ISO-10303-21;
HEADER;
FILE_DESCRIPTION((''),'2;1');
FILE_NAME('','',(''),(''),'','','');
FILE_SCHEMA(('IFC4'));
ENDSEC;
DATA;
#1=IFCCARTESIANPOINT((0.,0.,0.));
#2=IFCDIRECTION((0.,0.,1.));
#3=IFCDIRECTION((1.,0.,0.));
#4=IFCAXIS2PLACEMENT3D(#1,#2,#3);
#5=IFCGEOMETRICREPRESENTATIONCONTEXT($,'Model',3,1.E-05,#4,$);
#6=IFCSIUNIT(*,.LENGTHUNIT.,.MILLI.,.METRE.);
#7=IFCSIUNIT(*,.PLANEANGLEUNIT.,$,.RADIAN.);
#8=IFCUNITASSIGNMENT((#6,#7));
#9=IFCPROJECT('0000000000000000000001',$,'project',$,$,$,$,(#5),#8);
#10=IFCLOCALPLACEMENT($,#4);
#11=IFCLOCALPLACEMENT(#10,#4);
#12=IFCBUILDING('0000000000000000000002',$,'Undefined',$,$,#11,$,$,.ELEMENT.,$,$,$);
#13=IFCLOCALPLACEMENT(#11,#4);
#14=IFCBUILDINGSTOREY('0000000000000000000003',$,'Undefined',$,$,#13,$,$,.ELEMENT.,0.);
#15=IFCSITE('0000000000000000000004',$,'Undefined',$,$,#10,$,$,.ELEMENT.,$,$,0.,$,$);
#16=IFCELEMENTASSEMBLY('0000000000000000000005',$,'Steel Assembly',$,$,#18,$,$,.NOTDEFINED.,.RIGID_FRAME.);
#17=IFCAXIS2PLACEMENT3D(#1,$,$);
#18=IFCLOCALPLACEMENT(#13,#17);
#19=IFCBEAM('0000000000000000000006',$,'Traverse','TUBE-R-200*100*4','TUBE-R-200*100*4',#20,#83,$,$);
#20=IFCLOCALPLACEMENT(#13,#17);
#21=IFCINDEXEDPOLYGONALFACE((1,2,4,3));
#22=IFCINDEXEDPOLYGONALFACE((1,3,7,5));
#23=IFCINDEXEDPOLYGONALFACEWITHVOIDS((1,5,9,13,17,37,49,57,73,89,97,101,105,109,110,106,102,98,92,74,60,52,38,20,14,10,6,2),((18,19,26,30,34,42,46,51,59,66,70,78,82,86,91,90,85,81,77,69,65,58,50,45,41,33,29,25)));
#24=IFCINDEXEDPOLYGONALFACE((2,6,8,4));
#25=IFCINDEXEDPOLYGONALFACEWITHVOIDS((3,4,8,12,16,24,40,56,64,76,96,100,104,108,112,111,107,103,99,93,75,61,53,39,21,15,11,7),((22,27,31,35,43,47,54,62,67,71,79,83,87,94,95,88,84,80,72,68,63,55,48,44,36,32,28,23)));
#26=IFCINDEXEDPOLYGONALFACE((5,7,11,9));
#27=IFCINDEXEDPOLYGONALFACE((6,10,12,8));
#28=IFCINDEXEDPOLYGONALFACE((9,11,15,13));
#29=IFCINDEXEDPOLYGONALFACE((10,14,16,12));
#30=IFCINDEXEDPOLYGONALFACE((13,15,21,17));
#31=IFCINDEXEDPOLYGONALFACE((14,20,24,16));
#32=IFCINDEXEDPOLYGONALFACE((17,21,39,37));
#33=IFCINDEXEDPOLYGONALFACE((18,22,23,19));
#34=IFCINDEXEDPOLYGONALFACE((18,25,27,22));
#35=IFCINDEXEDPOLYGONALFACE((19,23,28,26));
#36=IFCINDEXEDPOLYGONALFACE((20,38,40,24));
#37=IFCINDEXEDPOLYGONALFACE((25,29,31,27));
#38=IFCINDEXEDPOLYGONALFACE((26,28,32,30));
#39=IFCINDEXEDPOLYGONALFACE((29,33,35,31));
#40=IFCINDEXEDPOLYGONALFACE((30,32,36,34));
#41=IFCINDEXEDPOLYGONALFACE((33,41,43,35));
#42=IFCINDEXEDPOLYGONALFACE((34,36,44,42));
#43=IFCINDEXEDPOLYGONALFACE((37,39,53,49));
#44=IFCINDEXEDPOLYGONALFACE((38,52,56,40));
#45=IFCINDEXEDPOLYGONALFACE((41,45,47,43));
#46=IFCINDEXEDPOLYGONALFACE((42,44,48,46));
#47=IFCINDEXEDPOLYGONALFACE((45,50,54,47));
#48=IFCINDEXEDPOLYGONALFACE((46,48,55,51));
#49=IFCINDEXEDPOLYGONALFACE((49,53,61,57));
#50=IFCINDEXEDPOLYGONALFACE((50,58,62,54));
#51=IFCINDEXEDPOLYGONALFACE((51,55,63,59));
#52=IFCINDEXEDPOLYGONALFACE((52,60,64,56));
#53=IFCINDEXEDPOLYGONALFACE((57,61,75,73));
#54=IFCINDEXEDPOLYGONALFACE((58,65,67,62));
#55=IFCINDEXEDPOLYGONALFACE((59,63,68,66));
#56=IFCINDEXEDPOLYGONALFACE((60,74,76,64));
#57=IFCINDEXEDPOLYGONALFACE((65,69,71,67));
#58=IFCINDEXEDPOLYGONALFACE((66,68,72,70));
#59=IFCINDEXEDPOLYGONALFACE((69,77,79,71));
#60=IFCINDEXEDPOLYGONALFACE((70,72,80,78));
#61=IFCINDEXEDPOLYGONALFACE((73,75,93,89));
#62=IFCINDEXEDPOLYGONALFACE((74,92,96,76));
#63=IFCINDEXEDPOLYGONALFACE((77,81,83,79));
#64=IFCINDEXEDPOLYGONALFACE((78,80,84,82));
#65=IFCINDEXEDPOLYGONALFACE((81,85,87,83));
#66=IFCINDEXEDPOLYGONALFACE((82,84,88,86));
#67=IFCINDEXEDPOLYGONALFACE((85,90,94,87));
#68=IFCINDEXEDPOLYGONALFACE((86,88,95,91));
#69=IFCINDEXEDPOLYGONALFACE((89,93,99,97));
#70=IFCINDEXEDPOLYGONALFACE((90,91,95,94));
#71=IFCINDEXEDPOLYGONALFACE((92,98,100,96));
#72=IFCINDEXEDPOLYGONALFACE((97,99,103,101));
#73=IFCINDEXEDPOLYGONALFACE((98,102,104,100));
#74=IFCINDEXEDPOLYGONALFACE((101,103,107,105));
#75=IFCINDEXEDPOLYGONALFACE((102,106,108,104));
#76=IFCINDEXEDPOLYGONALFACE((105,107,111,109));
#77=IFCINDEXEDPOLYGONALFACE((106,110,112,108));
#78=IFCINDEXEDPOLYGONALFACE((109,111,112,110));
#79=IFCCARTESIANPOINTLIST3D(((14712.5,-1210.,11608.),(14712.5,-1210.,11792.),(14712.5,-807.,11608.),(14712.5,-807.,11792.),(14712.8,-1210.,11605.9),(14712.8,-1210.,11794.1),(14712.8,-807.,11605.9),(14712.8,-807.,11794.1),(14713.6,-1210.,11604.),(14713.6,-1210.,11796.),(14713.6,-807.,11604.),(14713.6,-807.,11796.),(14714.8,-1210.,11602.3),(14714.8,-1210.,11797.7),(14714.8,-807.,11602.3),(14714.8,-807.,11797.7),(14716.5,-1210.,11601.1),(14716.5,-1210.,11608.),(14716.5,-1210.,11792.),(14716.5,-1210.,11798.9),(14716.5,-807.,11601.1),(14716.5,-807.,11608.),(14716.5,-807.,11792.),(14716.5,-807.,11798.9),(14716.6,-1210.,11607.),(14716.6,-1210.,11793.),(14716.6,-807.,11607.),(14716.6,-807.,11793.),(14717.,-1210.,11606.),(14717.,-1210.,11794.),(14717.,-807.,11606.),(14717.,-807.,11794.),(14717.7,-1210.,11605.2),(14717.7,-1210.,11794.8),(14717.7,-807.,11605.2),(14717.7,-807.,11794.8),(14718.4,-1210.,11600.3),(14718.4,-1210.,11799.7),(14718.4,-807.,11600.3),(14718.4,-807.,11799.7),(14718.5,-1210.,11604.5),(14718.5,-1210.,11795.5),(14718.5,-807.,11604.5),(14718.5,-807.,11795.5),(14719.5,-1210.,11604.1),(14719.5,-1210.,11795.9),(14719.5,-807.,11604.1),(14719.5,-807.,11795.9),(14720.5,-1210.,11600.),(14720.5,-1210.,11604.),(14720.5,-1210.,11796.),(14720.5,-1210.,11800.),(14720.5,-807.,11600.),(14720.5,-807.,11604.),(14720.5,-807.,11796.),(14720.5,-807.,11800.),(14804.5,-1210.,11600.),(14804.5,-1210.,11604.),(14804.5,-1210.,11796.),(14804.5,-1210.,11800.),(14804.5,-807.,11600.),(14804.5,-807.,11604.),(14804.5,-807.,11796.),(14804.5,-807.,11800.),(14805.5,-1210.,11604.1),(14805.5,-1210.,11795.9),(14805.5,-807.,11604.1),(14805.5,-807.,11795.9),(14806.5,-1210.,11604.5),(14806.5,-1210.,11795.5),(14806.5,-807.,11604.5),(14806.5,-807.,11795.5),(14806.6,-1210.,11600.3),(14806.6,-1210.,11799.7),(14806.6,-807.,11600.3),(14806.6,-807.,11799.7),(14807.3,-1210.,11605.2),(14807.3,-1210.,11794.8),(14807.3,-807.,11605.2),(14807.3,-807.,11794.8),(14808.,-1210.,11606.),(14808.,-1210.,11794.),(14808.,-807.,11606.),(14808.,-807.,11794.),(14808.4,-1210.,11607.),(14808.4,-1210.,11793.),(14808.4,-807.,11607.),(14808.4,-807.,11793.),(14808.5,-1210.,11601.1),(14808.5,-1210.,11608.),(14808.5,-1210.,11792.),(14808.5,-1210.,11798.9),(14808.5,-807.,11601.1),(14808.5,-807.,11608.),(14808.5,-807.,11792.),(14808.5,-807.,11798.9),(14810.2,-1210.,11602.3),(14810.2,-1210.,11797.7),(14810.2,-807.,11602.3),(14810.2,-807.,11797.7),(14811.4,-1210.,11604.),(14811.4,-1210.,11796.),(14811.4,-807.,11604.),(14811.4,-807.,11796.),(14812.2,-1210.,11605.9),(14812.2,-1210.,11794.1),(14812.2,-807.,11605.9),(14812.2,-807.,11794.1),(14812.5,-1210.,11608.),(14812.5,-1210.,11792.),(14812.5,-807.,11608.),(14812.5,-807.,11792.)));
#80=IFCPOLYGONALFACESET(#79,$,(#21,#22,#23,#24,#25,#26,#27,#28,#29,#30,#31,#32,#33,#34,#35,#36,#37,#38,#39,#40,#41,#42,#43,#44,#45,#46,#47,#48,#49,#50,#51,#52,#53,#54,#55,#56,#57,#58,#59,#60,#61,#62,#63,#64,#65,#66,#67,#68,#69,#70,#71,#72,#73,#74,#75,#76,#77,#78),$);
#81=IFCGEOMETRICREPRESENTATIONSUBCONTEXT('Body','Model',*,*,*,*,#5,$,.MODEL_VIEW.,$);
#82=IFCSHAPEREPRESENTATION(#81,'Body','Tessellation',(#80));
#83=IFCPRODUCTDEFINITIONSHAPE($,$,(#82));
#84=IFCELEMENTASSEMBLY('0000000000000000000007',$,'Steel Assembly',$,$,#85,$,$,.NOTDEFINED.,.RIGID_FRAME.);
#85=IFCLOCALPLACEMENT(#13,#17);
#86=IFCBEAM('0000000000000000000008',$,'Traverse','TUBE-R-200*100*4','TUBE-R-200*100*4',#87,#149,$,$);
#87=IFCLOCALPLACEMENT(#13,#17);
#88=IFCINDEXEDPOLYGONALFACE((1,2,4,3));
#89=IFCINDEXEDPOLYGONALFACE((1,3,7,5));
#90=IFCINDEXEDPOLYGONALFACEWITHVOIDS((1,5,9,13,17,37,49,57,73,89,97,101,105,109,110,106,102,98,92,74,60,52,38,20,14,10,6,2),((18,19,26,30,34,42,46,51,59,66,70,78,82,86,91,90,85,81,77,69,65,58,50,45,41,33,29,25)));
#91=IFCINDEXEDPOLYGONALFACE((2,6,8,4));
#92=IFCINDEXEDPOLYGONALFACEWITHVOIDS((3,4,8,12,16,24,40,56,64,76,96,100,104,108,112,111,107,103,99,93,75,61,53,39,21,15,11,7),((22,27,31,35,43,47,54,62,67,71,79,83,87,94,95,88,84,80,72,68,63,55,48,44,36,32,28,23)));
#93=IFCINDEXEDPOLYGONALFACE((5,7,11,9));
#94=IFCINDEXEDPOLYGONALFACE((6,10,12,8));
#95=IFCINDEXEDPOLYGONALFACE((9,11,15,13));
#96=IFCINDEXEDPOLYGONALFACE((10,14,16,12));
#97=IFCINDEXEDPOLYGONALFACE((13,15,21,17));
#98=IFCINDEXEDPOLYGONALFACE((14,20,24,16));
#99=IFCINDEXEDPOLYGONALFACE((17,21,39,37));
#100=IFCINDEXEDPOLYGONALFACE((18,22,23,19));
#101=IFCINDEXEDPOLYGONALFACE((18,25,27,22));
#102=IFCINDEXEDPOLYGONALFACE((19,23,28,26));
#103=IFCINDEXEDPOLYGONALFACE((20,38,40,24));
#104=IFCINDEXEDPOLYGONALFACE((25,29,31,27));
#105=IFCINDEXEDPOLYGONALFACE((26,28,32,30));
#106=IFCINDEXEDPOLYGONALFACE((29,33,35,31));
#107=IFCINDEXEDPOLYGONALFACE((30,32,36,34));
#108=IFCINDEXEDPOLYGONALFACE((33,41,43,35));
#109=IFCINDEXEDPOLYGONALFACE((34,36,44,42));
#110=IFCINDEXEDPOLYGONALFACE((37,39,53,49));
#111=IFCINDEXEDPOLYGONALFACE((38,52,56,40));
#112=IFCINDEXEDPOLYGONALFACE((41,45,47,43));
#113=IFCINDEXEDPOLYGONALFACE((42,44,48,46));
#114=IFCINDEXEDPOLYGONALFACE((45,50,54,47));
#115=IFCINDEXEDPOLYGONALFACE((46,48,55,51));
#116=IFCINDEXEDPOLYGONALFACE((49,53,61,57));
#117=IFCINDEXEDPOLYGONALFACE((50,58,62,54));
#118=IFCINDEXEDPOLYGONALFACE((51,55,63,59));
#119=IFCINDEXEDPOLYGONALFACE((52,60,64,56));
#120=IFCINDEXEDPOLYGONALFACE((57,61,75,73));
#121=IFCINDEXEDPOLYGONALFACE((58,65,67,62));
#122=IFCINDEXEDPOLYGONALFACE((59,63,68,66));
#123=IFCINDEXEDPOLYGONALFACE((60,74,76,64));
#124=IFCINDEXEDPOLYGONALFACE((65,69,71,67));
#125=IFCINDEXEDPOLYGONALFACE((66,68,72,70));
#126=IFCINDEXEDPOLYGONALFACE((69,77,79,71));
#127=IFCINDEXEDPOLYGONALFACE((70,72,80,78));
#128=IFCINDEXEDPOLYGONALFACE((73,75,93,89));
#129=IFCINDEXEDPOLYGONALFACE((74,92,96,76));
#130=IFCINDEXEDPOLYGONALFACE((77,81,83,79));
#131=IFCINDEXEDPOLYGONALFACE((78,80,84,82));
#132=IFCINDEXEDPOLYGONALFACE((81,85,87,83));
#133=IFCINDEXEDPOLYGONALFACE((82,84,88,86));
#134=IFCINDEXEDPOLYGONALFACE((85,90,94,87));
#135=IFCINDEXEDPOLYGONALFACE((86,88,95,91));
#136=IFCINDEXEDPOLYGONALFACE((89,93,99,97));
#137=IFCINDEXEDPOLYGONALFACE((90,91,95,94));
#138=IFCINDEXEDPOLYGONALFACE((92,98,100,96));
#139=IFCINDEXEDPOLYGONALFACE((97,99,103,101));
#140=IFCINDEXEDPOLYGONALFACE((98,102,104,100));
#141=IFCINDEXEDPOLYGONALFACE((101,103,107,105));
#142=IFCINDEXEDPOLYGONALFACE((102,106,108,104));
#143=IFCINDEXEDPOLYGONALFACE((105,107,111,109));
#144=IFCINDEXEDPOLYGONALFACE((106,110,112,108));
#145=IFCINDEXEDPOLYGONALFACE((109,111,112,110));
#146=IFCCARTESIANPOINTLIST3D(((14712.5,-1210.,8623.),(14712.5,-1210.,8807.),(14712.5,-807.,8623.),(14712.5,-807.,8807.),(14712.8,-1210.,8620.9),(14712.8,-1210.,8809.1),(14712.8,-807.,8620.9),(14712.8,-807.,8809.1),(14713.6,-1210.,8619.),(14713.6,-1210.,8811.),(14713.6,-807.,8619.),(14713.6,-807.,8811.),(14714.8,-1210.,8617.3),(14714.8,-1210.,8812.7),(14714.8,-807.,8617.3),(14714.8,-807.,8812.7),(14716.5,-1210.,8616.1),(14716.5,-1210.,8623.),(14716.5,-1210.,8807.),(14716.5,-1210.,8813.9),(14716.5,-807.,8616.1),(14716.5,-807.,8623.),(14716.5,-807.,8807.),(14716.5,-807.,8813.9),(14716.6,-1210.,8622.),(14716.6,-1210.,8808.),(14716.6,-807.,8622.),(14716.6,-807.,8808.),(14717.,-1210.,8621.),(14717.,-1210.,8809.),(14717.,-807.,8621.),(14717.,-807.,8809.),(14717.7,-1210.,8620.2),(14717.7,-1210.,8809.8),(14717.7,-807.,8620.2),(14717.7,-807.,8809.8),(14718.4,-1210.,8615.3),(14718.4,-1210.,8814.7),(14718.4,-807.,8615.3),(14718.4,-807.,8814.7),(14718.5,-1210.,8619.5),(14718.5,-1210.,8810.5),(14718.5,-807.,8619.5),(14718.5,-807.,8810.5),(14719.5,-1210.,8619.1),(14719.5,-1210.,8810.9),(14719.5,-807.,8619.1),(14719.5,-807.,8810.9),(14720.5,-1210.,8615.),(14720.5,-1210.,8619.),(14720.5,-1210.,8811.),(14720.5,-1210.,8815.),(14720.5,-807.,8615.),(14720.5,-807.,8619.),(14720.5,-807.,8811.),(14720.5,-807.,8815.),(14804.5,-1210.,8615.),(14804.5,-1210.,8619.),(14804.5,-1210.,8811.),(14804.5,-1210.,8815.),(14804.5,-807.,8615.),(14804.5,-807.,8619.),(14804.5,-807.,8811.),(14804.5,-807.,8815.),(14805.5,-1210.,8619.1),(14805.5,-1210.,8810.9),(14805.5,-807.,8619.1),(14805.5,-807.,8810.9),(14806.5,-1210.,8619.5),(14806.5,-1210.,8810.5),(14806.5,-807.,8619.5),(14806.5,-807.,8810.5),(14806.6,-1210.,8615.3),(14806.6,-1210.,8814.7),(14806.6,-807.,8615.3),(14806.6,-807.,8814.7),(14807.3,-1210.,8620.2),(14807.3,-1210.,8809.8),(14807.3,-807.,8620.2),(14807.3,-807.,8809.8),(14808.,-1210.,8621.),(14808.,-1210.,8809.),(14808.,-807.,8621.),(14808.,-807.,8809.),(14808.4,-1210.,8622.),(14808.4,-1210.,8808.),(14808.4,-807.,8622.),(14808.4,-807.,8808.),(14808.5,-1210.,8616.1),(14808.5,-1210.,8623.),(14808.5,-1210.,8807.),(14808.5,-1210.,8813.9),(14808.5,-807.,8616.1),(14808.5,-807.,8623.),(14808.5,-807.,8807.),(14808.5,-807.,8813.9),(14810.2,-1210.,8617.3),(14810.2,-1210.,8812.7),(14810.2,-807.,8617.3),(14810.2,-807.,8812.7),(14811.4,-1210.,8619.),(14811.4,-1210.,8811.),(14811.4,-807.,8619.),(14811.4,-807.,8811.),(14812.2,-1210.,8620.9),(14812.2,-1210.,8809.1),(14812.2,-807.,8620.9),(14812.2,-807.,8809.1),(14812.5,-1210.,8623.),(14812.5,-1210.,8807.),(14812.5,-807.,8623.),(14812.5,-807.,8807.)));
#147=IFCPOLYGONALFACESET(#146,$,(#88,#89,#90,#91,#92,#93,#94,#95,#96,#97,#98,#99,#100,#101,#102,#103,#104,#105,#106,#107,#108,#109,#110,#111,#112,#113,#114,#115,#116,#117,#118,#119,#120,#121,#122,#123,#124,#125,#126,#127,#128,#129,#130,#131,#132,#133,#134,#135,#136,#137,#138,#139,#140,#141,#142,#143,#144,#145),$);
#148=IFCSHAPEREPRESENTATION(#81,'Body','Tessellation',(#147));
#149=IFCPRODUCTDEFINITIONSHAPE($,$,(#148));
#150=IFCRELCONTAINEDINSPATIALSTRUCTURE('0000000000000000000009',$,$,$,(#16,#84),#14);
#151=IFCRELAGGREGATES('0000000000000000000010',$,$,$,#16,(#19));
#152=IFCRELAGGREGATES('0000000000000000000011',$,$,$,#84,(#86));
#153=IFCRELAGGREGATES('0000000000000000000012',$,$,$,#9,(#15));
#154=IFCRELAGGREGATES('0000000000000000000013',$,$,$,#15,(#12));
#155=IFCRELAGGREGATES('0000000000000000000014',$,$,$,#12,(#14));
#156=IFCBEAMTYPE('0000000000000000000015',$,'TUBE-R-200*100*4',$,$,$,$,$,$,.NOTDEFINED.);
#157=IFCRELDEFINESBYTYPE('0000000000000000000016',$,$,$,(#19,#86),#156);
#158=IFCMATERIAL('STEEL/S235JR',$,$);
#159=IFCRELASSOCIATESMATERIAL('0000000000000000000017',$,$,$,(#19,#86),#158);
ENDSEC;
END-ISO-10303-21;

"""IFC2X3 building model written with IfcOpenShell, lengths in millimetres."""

from ifc_helpers import new_model, si_unit, frame, origin_with_axes, origin_2d_with_axis, place, context, subcontext, project, spatial, hollow_rectangle, extrude, material, type_object, element, aggregate, save


model = new_model("IFC2X3")

# Units and contexts
model_context = context("Model", 3, precision=1e-05, world=origin_with_axes())
body_context = subcontext(model_context, "Body", "Model", "MODEL_VIEW")
ifc_project = project(units=[si_unit("LENGTHUNIT", "METRE", prefix="MILLI"), si_unit("PLANEANGLEUNIT", "RADIAN")], contexts=[model_context])

# Site, building, storey
site_placement = place(None, origin_with_axes())
site = spatial("IfcSite", under=ifc_project, at=site_placement, Name="Undefined", CompositionType="ELEMENT", RefElevation=0.0)
building_placement = place(site_placement, origin_with_axes())
building = spatial("IfcBuilding", under=site, at=building_placement, Name="Undefined", CompositionType="ELEMENT")
storey_placement = place(building_placement, origin_with_axes())
storey = spatial("IfcBuildingStorey", under=building, at=storey_placement, Name="Undefined", CompositionType="ELEMENT", Elevation=0.0)

# Element assemblies, beams
assembly_1_placement = place(storey_placement, origin_with_axes())
assembly_1 = element("IfcElementAssembly", 1, at=assembly_1_placement, inside=storey, Name="Steel Assembly", AssemblyPlace="NOTDEFINED", PredefinedType="RIGID_FRAME")
ifc_material_1 = material(Name="STEEL/S235JR")
beam_type_1 = type_object("IfcBeamType", Name="TUBE-R-200*100*4", PredefinedType="NOTDEFINED")
beam_1_placement = place(assembly_1_placement, frame((14762.5, -807.0, 11700.0), z_axis=(0.0, 0.0, 1.0), x_axis=(0.0, -1.0, 0.0)))
beam_1 = element("IfcBeam", 2, at=beam_1_placement, type_object=beam_type_1, material=ifc_material_1, Name="Traverse", Description="TUBE-R-200*100*4", ObjectType="TUBE-R-200*100*4", context=body_context, shape_type="SweptSolid", body=[
    extrude(hollow_rectangle(XDim=100.0, YDim=200.0, WallThickness=4.0, InnerFilletRadius=4.0, OuterFilletRadius=8.0, at=origin_2d_with_axis()), frame((403.0, 0.0, 0.0), z_axis=(-1.0, 0.0, 0.0), x_axis=(0.0, -1.0, 0.0)), (0.0, 0.0, 1.0), 403.0),
])
aggregate(assembly_1, [beam_1])
assembly_2_placement = place(storey_placement, origin_with_axes())
assembly_2 = element("IfcElementAssembly", 3, at=assembly_2_placement, inside=storey, Name="Steel Assembly", AssemblyPlace="NOTDEFINED", PredefinedType="RIGID_FRAME")
beam_2_placement = place(assembly_2_placement, frame((14762.5, -807.0, 8715.0), z_axis=(0.0, 0.0, 1.0), x_axis=(0.0, -1.0, 0.0)))
beam_2 = element("IfcBeam", 4, at=beam_2_placement, type_object=beam_type_1, material=ifc_material_1, Name="Traverse", Description="TUBE-R-200*100*4", ObjectType="TUBE-R-200*100*4", context=body_context, shape_type="SweptSolid", body=[
    extrude(hollow_rectangle(XDim=100.0, YDim=200.0, WallThickness=4.0, InnerFilletRadius=4.0, OuterFilletRadius=8.0, at=origin_2d_with_axis()), frame((403.0, 0.0, 0.0), z_axis=(-1.0, 0.0, 0.0), x_axis=(0.0, -1.0, 0.0)), (0.0, 0.0, 1.0), 403.0),
])
aggregate(assembly_2, [beam_2])

save(model, "model.ifc")
